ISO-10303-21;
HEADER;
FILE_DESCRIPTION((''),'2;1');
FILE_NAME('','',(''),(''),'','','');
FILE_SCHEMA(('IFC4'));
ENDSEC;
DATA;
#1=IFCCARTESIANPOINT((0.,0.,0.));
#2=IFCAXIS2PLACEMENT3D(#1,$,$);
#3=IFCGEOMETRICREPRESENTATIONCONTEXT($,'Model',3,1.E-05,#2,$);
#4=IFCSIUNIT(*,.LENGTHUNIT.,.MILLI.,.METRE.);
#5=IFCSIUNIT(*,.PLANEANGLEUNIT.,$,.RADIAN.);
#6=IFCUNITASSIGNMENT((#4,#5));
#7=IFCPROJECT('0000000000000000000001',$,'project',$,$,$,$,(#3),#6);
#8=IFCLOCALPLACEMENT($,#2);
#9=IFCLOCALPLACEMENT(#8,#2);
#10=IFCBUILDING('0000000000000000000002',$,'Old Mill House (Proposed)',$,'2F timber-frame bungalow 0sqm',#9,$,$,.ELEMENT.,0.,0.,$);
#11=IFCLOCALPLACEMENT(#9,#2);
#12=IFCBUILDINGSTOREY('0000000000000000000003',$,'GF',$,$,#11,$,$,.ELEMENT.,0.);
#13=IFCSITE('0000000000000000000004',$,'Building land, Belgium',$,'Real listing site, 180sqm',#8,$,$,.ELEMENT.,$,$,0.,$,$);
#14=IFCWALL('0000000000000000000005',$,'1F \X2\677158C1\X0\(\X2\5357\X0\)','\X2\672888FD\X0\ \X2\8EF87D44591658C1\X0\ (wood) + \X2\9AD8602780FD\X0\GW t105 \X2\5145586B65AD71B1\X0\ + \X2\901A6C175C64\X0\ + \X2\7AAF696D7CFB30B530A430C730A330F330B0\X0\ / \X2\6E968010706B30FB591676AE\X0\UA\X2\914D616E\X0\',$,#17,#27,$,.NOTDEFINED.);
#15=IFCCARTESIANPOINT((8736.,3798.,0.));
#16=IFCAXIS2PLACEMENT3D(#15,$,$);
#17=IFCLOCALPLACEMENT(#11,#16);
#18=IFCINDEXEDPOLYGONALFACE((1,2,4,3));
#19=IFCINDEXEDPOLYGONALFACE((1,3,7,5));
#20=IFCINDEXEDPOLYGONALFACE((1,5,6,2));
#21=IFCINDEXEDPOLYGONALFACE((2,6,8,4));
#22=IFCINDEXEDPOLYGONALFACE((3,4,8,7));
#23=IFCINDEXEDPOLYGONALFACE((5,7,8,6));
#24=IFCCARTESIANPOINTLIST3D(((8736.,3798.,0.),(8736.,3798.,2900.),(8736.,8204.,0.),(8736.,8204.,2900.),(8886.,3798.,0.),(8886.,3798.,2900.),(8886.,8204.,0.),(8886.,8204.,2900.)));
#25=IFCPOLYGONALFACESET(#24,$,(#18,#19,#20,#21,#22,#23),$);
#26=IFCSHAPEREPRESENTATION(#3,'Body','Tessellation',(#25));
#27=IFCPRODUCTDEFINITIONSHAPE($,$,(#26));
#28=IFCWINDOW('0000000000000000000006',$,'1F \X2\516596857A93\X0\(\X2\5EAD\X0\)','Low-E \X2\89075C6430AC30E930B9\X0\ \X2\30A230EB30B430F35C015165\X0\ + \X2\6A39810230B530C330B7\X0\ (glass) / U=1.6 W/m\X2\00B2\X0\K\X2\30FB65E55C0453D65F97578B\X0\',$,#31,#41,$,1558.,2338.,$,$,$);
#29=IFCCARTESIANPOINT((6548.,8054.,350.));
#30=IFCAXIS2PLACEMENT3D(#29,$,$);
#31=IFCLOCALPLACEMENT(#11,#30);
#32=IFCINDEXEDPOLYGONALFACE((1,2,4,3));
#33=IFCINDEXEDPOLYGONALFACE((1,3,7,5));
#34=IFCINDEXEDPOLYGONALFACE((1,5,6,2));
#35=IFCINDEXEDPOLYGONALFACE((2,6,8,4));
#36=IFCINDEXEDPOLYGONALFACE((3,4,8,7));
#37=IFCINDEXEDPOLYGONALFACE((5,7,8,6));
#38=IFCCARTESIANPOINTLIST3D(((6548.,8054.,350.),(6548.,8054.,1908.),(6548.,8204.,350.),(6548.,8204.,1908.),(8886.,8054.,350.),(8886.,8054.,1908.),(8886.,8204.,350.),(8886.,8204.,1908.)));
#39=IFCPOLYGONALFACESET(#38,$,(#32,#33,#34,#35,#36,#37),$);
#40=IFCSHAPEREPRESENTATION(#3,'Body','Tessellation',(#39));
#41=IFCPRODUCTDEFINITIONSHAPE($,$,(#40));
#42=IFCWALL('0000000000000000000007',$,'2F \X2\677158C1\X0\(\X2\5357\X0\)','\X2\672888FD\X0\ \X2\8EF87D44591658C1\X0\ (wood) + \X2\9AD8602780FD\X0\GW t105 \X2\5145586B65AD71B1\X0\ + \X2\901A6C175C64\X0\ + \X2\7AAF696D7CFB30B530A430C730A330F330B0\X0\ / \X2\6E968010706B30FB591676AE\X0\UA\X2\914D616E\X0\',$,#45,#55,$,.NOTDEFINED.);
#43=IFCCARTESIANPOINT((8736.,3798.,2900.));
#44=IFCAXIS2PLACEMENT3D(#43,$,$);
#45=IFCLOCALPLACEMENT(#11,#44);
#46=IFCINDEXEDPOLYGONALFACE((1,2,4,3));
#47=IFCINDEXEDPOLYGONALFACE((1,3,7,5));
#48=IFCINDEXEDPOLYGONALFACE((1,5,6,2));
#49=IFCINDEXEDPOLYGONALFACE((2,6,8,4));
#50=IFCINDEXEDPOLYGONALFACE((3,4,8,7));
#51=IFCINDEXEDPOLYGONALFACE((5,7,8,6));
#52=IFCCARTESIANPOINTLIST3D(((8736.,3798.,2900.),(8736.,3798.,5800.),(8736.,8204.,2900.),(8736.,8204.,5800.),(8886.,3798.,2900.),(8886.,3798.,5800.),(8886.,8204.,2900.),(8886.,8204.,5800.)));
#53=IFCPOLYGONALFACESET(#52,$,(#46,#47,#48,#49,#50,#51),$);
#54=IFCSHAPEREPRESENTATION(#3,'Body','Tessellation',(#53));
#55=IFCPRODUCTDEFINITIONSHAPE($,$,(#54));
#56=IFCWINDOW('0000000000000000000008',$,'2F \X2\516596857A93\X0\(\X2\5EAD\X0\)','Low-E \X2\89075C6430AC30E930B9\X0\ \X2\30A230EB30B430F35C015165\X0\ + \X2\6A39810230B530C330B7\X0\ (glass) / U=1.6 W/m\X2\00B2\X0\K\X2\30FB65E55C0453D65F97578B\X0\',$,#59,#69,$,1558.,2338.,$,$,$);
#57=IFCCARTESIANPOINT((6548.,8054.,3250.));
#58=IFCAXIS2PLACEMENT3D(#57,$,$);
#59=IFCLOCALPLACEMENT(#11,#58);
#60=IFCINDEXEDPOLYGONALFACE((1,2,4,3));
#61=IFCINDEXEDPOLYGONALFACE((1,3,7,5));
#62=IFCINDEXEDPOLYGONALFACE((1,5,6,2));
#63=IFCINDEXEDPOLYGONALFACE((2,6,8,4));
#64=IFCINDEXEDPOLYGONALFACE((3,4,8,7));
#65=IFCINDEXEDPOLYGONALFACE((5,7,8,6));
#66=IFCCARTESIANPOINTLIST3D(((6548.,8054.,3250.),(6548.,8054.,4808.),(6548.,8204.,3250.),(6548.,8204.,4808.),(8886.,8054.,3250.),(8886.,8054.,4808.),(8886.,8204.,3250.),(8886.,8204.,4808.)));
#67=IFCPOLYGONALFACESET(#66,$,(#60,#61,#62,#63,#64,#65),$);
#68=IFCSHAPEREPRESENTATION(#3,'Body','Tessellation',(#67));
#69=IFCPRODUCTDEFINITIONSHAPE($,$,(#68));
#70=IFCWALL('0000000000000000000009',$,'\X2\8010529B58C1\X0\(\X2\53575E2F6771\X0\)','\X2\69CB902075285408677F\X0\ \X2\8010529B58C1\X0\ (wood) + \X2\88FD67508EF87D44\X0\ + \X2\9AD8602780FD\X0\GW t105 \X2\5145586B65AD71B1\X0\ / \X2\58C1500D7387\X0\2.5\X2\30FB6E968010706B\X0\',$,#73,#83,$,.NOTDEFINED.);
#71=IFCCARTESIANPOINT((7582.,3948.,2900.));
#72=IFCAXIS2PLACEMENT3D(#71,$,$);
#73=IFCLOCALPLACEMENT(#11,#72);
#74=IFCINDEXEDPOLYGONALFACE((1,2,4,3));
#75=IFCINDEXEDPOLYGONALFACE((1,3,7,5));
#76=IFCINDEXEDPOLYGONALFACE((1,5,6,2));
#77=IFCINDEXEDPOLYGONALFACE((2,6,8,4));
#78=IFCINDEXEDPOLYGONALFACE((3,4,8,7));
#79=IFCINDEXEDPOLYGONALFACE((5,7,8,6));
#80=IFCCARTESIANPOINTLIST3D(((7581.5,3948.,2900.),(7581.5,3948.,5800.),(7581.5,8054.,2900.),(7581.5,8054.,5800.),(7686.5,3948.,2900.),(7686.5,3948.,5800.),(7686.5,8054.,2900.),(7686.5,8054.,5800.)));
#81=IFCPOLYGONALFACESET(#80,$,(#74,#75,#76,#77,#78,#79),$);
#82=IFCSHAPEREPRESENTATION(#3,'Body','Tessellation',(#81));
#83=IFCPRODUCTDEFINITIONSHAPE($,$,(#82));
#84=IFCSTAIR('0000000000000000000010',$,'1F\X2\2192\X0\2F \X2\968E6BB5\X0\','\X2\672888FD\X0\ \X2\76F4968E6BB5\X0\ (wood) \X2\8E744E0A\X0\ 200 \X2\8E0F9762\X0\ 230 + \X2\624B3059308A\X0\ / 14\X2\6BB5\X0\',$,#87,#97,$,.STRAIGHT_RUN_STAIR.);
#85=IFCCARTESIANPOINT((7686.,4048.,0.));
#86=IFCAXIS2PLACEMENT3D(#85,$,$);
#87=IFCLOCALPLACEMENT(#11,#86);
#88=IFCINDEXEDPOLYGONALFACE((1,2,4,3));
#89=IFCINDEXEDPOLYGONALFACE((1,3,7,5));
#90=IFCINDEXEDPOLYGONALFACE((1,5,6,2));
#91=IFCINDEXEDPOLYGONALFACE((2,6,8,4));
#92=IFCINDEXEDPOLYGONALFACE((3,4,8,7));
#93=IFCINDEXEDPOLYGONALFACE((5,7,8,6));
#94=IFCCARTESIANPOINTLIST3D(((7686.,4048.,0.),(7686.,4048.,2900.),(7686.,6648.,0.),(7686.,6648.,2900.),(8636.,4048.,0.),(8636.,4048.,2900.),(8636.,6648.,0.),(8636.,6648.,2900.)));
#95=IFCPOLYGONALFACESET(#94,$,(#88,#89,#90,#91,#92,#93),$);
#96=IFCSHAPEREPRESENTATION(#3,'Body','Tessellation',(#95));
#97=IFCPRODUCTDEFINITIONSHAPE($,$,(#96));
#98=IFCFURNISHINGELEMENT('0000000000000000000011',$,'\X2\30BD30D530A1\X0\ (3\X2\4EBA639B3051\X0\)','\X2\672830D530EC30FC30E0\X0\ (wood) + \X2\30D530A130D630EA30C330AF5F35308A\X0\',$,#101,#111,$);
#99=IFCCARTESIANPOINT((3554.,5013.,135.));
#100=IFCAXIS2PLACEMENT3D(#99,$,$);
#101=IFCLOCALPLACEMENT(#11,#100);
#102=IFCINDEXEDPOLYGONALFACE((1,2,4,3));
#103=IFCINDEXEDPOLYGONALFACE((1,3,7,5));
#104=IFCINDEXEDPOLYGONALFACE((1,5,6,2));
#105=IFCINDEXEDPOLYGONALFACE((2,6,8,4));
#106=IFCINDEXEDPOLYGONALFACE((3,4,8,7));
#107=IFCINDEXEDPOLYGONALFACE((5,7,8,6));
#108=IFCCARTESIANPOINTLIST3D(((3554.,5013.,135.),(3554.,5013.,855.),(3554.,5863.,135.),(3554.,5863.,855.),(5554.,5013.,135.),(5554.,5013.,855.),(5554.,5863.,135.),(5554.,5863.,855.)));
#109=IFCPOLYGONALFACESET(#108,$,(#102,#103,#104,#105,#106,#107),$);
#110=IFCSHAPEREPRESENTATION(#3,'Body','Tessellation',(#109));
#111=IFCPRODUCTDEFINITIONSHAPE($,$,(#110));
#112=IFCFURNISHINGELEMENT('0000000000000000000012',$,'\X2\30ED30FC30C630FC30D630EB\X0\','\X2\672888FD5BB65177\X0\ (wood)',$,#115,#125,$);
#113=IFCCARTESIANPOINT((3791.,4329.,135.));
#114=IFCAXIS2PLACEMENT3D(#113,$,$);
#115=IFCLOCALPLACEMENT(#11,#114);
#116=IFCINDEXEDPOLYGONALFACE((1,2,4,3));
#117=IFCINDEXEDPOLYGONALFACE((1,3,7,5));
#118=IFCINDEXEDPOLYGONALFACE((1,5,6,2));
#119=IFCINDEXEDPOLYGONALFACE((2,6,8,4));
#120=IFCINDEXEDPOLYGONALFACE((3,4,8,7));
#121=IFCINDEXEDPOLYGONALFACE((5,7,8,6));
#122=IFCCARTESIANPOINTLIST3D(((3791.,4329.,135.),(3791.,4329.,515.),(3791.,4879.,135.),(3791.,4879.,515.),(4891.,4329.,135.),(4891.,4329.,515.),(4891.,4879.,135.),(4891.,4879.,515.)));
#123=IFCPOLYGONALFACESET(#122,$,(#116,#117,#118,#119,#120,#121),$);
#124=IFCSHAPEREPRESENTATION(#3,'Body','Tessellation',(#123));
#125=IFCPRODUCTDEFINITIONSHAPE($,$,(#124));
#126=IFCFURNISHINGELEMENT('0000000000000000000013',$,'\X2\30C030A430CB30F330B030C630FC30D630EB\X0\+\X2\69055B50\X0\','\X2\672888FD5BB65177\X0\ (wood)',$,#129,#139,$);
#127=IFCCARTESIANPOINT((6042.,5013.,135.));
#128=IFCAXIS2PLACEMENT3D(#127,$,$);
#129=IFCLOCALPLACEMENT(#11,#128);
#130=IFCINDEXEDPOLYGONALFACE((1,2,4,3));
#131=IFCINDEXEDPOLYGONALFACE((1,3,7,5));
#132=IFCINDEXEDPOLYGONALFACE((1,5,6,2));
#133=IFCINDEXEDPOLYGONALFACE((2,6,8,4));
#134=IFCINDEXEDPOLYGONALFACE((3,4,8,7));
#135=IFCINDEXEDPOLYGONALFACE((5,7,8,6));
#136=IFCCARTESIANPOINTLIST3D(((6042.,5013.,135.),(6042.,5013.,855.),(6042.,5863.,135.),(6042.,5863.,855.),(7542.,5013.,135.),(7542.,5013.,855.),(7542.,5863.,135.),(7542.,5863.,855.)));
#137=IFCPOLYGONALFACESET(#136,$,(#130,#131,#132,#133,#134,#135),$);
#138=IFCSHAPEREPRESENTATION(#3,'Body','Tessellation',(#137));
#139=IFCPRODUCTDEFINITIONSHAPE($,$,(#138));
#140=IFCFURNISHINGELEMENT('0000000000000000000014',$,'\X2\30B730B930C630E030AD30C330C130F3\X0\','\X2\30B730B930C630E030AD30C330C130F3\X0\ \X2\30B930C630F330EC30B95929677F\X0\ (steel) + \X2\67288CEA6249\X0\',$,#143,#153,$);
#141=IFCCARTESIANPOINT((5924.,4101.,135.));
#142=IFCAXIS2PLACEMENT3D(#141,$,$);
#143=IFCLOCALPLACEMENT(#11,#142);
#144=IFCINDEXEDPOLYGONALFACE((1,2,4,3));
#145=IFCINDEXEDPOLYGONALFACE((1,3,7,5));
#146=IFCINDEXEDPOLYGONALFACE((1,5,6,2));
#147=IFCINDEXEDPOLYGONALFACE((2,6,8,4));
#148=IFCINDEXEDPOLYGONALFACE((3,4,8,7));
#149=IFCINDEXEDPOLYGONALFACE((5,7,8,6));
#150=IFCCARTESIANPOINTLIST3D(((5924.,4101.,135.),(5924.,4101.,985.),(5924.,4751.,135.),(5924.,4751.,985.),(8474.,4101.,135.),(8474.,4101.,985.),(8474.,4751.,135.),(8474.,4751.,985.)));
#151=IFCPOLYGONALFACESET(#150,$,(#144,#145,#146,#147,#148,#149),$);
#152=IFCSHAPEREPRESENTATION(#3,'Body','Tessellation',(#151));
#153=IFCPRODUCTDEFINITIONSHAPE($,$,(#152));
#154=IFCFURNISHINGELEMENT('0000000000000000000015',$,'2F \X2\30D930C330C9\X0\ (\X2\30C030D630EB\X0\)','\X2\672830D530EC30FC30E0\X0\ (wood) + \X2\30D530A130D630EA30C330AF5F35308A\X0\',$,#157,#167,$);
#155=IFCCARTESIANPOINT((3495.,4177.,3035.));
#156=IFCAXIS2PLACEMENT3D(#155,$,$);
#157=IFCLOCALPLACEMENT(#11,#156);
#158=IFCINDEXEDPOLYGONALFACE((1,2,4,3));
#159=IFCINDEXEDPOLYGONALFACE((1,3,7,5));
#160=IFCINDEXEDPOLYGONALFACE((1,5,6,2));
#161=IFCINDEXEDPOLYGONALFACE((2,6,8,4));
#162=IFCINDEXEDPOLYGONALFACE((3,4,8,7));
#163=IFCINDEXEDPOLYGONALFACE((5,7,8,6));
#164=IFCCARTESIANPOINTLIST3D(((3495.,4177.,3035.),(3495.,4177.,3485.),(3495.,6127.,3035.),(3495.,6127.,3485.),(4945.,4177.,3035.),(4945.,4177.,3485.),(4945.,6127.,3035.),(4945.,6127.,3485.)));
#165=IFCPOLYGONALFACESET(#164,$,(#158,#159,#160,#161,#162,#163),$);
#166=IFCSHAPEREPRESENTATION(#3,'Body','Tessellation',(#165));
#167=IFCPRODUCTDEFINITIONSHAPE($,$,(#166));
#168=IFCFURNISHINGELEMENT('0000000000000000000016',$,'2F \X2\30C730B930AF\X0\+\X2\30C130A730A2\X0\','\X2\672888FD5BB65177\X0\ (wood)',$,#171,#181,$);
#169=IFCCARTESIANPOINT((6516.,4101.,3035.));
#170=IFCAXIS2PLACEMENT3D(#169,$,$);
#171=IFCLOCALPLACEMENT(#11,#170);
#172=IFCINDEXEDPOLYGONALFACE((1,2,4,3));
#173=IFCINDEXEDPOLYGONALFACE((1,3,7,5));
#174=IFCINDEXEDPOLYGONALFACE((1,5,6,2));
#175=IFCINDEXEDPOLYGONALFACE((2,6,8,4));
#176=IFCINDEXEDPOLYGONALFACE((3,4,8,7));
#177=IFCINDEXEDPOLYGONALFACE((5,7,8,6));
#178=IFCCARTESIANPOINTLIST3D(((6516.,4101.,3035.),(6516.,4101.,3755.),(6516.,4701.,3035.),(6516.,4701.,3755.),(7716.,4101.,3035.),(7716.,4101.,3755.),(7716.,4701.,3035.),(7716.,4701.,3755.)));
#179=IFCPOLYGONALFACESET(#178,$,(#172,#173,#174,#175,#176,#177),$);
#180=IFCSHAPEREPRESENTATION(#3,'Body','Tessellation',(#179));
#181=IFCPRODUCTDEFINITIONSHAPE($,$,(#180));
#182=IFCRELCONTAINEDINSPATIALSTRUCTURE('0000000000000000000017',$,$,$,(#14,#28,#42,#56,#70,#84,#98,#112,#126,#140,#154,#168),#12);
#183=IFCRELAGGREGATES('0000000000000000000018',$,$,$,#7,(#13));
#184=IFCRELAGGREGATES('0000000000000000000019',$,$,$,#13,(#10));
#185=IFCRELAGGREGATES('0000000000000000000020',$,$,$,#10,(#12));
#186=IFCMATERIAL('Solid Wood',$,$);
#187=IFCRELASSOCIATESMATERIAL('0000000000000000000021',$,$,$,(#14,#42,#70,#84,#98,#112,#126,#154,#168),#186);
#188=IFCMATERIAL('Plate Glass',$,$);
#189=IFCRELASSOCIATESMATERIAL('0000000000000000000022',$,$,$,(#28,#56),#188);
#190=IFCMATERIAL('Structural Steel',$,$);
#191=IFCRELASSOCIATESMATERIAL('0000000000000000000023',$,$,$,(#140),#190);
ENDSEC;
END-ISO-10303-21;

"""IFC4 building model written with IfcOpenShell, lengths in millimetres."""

from ifc_helpers import new_model, si_unit, frame, frame_2d, origin, place, context, project, spatial, rectangle, extrude, material, element, fill, save


model = new_model("IFC4")

# Units and contexts
model_context = context("Model", 3, precision=1e-05, world=origin())
ifc_project = project(units=[si_unit("LENGTHUNIT", "METRE", prefix="MILLI"), si_unit("PLANEANGLEUNIT", "RADIAN")], contexts=[model_context])

# Site, building, storey
site_placement = place(None, origin())
site = spatial("IfcSite", under=ifc_project, at=site_placement, Name="Building land, Belgium", ObjectType="Real listing site, 180sqm", CompositionType="ELEMENT", RefElevation=0.0)
building_placement = place(site_placement, origin())
building = spatial("IfcBuilding", under=site, at=building_placement, Name="Old Mill House (Proposed)", ObjectType="2F timber-frame bungalow 0sqm", CompositionType="ELEMENT", ElevationOfRefHeight=0.0, ElevationOfTerrain=0.0)
storey_placement = place(building_placement, origin())
storey = spatial("IfcBuildingStorey", under=building, at=storey_placement, Name="GF", CompositionType="ELEMENT", Elevation=0.0)

# Wall, opening, window
ifc_material_1 = material(Name="Solid Wood")
wall_1_placement = place(storey_placement, frame((8736.0, 3798.0, 0.0)))
wall_1 = element("IfcWall", 1, at=wall_1_placement, inside=storey, material=ifc_material_1, Name="1F 東壁(南)", Description="木製 軸組外壁 (wood) + 高性能GW t105 充填断熱 + 通気層 + 窯業系サイディング / 準耐火・外皮UA配慮", PredefinedType="NOTDEFINED", context=model_context, shape_type="SweptSolid", body=[
    extrude(rectangle(XDim=150.0, YDim=4406.0, at=frame_2d((75.0, 2203.0))), frame((8736.0, 3798.0, 0.0)), (0.0, 0.0, 1.0), 2900.0),
])
opening_1_placement = place(storey_placement, frame((6548.0, 8054.0, 350.0)))
opening_1 = element("IfcOpeningElement", 2, at=opening_1_placement, cuts=wall_1, PredefinedType="NOTDEFINED", context=model_context, shape_type="SweptSolid", body=[
    extrude(rectangle(XDim=2338.0, YDim=150.0, at=frame_2d((1169.0, 75.0))), frame((6548.0, 8054.0, 350.0)), (0.0, 0.0, 1.0), 1558.0),
])
ifc_material_2 = material(Name="Plate Glass")
window_1_placement = place(storey_placement, frame((6548.0, 8054.0, 350.0)))
window_1 = element("IfcWindow", 3, at=window_1_placement, inside=storey, material=ifc_material_2, Name="1F 入隅窓(庭)", Description="Low-E 複層ガラス アルゴン封入 + 樹脂サッシ (glass) / U=1.6 W/m²K・日射取得型", OverallHeight=1558.0, OverallWidth=2338.0, context=model_context, shape_type="SweptSolid", body=[
    extrude(rectangle(XDim=2338.0, YDim=150.0, at=frame_2d((1169.0, 75.0))), frame((6548.0, 8054.0, 350.0)), (0.0, 0.0, 1.0), 1558.0),
])
fill(opening_1, window_1)

# Wall, opening, window
wall_2_placement = place(storey_placement, frame((8736.0, 3798.0, 2900.0)))
wall_2 = element("IfcWall", 4, at=wall_2_placement, inside=storey, material=ifc_material_1, Name="2F 東壁(南)", Description="木製 軸組外壁 (wood) + 高性能GW t105 充填断熱 + 通気層 + 窯業系サイディング / 準耐火・外皮UA配慮", PredefinedType="NOTDEFINED", context=model_context, shape_type="SweptSolid", body=[
    extrude(rectangle(XDim=150.0, YDim=4406.0, at=frame_2d((75.0, 2203.0))), frame((8736.0, 3798.0, 2900.0)), (0.0, 0.0, 1.0), 2900.0),
])
opening_2_placement = place(storey_placement, frame((6548.0, 8054.0, 3250.0)))
opening_2 = element("IfcOpeningElement", 5, at=opening_2_placement, cuts=wall_2, PredefinedType="NOTDEFINED", context=model_context, shape_type="SweptSolid", body=[
    extrude(rectangle(XDim=2338.0, YDim=150.0, at=frame_2d((1169.0, 75.0))), frame((6548.0, 8054.0, 3250.0)), (0.0, 0.0, 1.0), 1558.0),
])
window_2_placement = place(storey_placement, frame((6548.0, 8054.0, 3250.0)))
window_2 = element("IfcWindow", 6, at=window_2_placement, inside=storey, material=ifc_material_2, Name="2F 入隅窓(庭)", Description="Low-E 複層ガラス アルゴン封入 + 樹脂サッシ (glass) / U=1.6 W/m²K・日射取得型", OverallHeight=1558.0, OverallWidth=2338.0, context=model_context, shape_type="SweptSolid", body=[
    extrude(rectangle(XDim=2338.0, YDim=150.0, at=frame_2d((1169.0, 75.0))), frame((6548.0, 8054.0, 3250.0)), (0.0, 0.0, 1.0), 1558.0),
])
fill(opening_2, window_2)

# Wall
wall_3_placement = place(storey_placement, frame((7582.0, 3948.0, 2900.0)))
element("IfcWall", 7, at=wall_3_placement, inside=storey, material=ifc_material_1, Name="耐力壁(南帯東)", Description="構造用合板 耐力壁 (wood) + 製材軸組 + 高性能GW t105 充填断熱 / 壁倍率2.5・準耐火", PredefinedType="NOTDEFINED", context=model_context, shape_type="SweptSolid", body=[
    extrude(rectangle(XDim=105.0, YDim=4106.0, at=frame_2d((52.0, 2053.0))), frame((7582.0, 3948.0, 2900.0)), (0.0, 0.0, 1.0), 2900.0),
])

# Stair
stair_placement = place(storey_placement, frame((7686.0, 4048.0, 0.0)))
element("IfcStair", 8, at=stair_placement, inside=storey, material=ifc_material_1, Name="1F→2F 階段", Description="木製 直階段 (wood) 蹴上 200 踏面 230 + 手すり / 14段", PredefinedType="STRAIGHT_RUN_STAIR", context=model_context, shape_type="SweptSolid", body=[
    extrude(rectangle(XDim=950.0, YDim=2600.0, at=frame_2d((475.0, 1300.0))), frame((7686.0, 4048.0, 0.0)), (0.0, 0.0, 1.0), 2900.0),
])

# Furnishing elements
furnishing_1_placement = place(storey_placement, frame((3554.0, 5013.0, 135.0)))
element("IfcFurnishingElement", 9, at=furnishing_1_placement, inside=storey, material=ifc_material_1, Name="ソファ (3人掛け)", Description="木フレーム (wood) + ファブリック張り", context=model_context, shape_type="SweptSolid", body=[
    extrude(rectangle(XDim=2000.0, YDim=850.0, at=frame_2d((1000.0, 425.0))), frame((3554.0, 5013.0, 135.0)), (0.0, 0.0, 1.0), 720.0),
])
furnishing_2_placement = place(storey_placement, frame((3791.0, 4329.0, 135.0)))
element("IfcFurnishingElement", 10, at=furnishing_2_placement, inside=storey, material=ifc_material_1, Name="ローテーブル", Description="木製家具 (wood)", context=model_context, shape_type="SweptSolid", body=[
    extrude(rectangle(XDim=1100.0, YDim=550.0, at=frame_2d((550.0, 275.0))), frame((3791.0, 4329.0, 135.0)), (0.0, 0.0, 1.0), 380.0),
])
furnishing_3_placement = place(storey_placement, frame((6042.0, 5013.0, 135.0)))
element("IfcFurnishingElement", 11, at=furnishing_3_placement, inside=storey, material=ifc_material_1, Name="ダイニングテーブル+椅子", Description="木製家具 (wood)", context=model_context, shape_type="SweptSolid", body=[
    extrude(rectangle(XDim=1500.0, YDim=850.0, at=frame_2d((750.0, 425.0))), frame((6042.0, 5013.0, 135.0)), (0.0, 0.0, 1.0), 720.0),
])
ifc_material_3 = material(Name="Structural Steel")
furnishing_4_placement = place(storey_placement, frame((5924.0, 4101.0, 135.0)))
element("IfcFurnishingElement", 12, at=furnishing_4_placement, inside=storey, material=ifc_material_3, Name="システムキッチン", Description="システムキッチン ステンレス天板 (steel) + 木質扉", context=model_context, shape_type="SweptSolid", body=[
    extrude(rectangle(XDim=2550.0, YDim=650.0, at=frame_2d((1275.0, 325.0))), frame((5924.0, 4101.0, 135.0)), (0.0, 0.0, 1.0), 850.0),
])
furnishing_5_placement = place(storey_placement, frame((3495.0, 4177.0, 3035.0)))
element("IfcFurnishingElement", 13, at=furnishing_5_placement, inside=storey, material=ifc_material_1, Name="2F ベッド (ダブル)", Description="木フレーム (wood) + ファブリック張り", context=model_context, shape_type="SweptSolid", body=[
    extrude(rectangle(XDim=1450.0, YDim=1950.0, at=frame_2d((725.0, 975.0))), frame((3495.0, 4177.0, 3035.0)), (0.0, 0.0, 1.0), 450.0),
])
furnishing_6_placement = place(storey_placement, frame((6516.0, 4101.0, 3035.0)))
element("IfcFurnishingElement", 14, at=furnishing_6_placement, inside=storey, material=ifc_material_1, Name="2F デスク+チェア", Description="木製家具 (wood)", context=model_context, shape_type="SweptSolid", body=[
    extrude(rectangle(XDim=1200.0, YDim=600.0, at=frame_2d((600.0, 300.0))), frame((6516.0, 4101.0, 3035.0)), (0.0, 0.0, 1.0), 720.0),
])

save(model, "model.ifc")
